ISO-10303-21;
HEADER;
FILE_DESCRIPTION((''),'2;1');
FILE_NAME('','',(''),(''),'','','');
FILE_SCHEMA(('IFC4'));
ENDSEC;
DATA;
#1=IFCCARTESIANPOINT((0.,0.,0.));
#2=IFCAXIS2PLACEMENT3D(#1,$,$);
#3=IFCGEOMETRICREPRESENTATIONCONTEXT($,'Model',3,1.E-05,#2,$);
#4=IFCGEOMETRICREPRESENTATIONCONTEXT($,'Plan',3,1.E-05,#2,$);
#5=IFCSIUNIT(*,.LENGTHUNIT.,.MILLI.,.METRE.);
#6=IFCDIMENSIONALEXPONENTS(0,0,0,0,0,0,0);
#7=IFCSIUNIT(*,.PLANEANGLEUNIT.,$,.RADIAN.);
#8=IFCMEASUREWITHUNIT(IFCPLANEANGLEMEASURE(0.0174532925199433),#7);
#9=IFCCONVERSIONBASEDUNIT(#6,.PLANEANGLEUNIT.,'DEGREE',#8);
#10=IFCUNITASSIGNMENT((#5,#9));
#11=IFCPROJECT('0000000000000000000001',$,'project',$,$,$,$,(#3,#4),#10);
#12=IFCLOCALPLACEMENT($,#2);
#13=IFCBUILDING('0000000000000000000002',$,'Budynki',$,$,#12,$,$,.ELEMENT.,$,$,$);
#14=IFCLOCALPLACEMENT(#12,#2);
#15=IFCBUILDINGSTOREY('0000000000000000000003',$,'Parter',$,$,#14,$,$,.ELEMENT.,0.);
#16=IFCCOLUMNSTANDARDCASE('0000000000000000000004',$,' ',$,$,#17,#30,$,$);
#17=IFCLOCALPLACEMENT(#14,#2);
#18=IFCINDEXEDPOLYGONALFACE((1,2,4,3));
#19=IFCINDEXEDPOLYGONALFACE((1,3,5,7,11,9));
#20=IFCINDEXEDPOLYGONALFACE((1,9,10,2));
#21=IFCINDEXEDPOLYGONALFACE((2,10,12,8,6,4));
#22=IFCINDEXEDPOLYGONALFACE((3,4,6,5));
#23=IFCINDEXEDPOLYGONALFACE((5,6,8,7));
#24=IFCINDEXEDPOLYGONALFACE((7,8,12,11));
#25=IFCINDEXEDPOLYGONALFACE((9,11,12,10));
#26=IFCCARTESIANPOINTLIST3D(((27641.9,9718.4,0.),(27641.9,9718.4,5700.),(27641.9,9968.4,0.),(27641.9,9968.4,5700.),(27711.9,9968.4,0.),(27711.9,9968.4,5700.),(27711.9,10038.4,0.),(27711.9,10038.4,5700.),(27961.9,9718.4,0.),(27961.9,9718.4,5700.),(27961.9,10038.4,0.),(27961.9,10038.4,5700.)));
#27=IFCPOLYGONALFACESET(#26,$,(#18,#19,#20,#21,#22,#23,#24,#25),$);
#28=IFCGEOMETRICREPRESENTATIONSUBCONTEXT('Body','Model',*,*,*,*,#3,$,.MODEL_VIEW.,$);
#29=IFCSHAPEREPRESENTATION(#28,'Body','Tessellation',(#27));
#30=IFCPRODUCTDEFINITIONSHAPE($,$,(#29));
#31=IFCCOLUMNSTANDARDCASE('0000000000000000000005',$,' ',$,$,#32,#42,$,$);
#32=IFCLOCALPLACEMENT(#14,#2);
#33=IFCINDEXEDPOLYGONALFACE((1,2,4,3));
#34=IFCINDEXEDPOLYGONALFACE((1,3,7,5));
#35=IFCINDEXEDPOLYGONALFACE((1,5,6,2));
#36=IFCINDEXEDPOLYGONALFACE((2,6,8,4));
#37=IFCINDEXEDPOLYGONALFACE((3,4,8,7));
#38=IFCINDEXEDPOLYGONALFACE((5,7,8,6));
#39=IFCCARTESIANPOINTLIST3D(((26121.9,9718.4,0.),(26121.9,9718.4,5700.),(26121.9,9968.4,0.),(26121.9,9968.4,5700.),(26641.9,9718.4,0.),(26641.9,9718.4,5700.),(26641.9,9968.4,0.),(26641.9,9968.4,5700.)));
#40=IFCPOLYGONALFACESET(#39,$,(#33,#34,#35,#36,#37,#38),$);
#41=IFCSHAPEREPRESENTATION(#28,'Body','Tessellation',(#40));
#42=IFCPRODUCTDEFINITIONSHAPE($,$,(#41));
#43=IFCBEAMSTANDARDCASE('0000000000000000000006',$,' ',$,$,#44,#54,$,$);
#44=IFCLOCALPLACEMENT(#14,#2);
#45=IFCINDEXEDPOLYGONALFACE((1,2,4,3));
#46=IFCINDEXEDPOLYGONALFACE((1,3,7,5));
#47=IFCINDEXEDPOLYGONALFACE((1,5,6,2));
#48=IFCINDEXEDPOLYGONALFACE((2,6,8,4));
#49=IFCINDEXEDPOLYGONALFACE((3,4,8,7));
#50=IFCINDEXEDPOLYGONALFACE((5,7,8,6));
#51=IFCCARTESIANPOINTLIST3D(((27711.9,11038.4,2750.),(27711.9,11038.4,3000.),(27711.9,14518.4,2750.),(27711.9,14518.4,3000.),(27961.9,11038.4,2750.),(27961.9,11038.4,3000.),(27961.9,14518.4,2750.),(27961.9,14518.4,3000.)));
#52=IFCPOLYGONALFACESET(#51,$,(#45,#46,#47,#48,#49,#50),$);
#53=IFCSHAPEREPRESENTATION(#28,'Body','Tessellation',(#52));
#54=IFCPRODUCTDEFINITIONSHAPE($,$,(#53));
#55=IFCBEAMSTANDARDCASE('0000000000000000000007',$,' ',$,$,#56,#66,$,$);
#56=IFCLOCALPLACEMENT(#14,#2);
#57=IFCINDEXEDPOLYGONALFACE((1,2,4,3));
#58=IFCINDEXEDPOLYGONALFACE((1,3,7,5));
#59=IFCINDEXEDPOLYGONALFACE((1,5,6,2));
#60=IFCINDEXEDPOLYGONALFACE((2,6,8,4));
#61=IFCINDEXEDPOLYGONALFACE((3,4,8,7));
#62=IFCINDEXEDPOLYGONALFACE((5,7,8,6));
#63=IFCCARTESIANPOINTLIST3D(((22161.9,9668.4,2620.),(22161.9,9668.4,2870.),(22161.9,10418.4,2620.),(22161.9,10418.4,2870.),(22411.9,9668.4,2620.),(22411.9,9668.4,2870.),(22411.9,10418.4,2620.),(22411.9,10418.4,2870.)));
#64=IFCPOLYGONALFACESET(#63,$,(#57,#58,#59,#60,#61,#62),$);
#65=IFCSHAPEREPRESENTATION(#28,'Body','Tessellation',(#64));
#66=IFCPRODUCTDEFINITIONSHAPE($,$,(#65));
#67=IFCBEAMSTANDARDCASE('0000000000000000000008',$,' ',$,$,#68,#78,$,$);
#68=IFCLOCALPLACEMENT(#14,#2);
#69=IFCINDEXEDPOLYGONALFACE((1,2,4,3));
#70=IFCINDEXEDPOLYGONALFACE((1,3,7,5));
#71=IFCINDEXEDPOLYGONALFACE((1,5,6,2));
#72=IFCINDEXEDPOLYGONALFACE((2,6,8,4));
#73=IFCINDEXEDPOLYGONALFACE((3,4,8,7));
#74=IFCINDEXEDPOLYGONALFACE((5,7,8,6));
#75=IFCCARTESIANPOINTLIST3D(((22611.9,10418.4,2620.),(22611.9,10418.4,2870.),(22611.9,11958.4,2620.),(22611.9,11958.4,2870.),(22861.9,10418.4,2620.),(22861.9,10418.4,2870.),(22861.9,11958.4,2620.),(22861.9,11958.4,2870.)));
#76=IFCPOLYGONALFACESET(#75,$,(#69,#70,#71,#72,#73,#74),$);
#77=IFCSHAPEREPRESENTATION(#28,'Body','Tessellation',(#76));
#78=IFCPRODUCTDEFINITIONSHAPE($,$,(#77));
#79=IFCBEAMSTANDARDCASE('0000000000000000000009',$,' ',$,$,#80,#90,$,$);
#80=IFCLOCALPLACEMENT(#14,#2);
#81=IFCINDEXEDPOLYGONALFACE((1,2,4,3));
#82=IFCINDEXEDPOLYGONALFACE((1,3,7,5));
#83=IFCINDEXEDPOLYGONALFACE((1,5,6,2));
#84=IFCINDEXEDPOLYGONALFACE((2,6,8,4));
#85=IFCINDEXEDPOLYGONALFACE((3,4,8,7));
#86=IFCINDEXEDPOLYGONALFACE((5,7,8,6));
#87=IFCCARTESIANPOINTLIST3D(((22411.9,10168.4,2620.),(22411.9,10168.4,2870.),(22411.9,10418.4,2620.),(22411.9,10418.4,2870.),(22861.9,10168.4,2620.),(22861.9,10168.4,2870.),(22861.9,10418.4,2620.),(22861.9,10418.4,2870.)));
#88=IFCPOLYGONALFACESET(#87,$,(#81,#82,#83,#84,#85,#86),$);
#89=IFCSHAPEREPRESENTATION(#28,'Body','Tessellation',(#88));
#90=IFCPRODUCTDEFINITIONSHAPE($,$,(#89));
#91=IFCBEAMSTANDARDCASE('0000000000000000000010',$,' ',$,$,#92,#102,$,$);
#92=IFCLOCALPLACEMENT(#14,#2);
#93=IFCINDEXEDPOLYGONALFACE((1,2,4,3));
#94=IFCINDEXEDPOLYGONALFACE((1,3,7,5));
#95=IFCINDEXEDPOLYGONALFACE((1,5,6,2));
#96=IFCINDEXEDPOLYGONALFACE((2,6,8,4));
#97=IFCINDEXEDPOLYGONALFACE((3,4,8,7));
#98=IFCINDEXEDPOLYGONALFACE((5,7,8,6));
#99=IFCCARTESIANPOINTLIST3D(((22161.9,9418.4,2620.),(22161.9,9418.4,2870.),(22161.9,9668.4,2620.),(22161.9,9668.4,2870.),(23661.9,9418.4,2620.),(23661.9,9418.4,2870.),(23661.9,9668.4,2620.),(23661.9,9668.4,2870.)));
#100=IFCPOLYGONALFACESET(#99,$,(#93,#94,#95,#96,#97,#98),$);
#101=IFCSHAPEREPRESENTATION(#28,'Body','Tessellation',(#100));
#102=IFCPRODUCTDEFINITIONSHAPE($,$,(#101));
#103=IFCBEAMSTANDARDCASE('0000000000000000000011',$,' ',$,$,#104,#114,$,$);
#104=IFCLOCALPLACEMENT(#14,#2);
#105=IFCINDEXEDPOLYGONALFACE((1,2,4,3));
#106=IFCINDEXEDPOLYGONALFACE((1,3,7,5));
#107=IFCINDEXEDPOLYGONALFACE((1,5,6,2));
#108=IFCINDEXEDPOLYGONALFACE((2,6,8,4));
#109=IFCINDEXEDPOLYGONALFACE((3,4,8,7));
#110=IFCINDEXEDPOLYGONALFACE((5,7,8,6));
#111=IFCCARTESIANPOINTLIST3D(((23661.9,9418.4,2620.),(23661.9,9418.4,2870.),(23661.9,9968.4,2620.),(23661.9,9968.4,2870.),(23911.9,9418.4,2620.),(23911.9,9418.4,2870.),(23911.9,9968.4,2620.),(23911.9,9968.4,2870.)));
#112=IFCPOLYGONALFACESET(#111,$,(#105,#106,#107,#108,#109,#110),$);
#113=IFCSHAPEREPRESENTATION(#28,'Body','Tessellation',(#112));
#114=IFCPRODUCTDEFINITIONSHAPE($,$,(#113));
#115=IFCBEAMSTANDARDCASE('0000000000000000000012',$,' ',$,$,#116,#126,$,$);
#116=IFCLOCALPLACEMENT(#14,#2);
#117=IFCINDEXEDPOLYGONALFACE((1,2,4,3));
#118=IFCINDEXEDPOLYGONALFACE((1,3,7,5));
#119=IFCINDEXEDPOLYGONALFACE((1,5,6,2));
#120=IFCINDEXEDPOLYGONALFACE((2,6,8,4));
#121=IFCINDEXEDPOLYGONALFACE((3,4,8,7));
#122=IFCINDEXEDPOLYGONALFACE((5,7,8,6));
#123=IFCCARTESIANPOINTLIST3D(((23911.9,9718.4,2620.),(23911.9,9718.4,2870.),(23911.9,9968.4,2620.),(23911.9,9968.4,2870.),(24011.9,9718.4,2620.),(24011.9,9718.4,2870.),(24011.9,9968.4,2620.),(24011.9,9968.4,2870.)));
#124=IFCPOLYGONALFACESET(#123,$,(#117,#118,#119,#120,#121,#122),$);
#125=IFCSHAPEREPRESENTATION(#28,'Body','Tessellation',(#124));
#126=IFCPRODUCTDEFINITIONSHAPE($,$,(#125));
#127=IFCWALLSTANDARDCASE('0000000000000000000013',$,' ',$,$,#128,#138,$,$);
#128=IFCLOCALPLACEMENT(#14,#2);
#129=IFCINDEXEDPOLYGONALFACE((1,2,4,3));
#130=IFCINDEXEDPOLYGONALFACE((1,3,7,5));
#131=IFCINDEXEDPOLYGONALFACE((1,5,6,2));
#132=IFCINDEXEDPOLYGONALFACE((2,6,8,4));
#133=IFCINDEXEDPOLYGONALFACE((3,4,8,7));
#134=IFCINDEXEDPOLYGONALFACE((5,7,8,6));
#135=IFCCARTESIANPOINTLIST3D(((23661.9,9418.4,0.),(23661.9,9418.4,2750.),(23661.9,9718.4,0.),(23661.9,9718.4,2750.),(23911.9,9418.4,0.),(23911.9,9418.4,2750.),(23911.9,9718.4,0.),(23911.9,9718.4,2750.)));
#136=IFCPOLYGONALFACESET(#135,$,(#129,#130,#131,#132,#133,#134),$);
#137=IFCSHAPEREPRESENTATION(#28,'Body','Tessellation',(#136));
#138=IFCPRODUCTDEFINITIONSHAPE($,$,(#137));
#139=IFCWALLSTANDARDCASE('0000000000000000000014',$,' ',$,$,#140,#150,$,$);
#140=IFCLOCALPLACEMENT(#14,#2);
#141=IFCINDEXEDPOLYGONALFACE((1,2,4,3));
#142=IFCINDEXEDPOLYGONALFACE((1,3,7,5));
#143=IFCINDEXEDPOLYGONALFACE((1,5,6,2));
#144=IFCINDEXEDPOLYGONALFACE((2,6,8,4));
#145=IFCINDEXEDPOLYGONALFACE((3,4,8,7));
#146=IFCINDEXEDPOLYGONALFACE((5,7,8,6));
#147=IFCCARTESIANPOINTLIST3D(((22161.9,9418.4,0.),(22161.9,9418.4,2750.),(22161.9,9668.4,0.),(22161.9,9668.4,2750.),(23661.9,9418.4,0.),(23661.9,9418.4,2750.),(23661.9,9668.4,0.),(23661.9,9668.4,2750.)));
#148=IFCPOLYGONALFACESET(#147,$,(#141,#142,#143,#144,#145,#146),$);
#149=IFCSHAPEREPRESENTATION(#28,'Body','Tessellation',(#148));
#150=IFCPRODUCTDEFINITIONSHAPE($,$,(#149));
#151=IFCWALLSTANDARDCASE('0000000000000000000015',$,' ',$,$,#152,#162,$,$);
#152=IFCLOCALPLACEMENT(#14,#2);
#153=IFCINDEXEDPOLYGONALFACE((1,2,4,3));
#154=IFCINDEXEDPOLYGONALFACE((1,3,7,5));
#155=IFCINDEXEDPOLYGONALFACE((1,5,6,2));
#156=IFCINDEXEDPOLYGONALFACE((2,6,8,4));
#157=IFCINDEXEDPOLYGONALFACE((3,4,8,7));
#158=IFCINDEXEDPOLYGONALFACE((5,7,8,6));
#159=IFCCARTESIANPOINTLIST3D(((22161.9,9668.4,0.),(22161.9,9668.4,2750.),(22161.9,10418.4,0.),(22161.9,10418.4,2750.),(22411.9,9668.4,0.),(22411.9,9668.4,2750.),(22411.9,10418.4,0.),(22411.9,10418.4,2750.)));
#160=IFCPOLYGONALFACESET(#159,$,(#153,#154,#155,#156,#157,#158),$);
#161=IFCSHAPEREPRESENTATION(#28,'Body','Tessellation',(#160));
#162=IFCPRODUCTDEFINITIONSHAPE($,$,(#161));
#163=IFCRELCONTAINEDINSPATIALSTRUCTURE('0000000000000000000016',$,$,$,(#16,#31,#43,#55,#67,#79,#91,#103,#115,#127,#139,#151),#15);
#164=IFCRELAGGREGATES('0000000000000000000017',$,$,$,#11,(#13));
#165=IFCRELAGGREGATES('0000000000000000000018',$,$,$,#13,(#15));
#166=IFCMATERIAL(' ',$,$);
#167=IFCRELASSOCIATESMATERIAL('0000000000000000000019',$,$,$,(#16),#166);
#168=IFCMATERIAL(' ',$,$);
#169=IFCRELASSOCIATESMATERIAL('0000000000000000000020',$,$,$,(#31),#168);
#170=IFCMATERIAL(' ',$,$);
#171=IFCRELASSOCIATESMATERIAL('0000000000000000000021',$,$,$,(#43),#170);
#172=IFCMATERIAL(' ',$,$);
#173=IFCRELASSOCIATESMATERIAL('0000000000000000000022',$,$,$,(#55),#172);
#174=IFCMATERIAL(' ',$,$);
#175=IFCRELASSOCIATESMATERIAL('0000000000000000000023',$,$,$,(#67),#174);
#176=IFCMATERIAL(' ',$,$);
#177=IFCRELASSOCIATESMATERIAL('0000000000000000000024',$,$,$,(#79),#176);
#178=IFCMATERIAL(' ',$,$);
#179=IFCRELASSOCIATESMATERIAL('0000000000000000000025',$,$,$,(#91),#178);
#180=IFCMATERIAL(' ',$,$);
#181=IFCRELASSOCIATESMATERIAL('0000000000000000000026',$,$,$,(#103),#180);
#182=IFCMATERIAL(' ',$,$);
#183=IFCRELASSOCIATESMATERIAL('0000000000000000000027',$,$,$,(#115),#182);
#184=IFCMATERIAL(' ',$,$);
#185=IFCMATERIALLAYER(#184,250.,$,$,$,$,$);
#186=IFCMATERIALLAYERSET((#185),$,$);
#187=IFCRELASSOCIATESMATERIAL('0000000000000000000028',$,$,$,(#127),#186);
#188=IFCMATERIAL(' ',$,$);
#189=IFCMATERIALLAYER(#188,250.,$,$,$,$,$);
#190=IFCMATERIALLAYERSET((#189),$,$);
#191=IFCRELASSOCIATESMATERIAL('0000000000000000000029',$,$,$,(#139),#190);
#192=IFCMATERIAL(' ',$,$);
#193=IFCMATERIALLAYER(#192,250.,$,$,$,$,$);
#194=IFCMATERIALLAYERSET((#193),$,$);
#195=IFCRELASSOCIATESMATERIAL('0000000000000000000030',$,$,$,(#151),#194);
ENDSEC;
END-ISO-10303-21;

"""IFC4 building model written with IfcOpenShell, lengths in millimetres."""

from ifc_helpers import new_model, entity, si_unit, converted_unit, frame, frame_2d, origin, origin_with_axes, place, context, subcontext, project, spatial, polyline, rectangle, outline, extrude, material, layer, layer_set, layer_usage, material_profile, profile_set, profile_usage, element, save


model = new_model("IFC4")

# Units and contexts
model_context = context("Model", 3, precision=1e-05, world=origin())
plan_context = context("Plan", 3, precision=1e-05, world=origin())
body_context = subcontext(model_context, "Body", "Model", "MODEL_VIEW")
ifc_project = project(units=[si_unit("LENGTHUNIT", "METRE", prefix="MILLI"), converted_unit("PLANEANGLEUNIT", "DEGREE", entity("IfcPlaneAngleMeasure", 0.0174532925199433), si_unit("PLANEANGLEUNIT", "RADIAN"), dimensions=[0, 0, 0, 0, 0, 0, 0])], contexts=[model_context, plan_context])

# Building, storey
building_placement = place(None, origin())
building = spatial("IfcBuilding", under=ifc_project, at=building_placement, Name="Budynki", CompositionType="ELEMENT")
storey_placement = place(building_placement, origin())
storey = spatial("IfcBuildingStorey", under=building, at=storey_placement, Name="Parter", CompositionType="ELEMENT", Elevation=0.0)

# Columns
ifc_material_1 = material(Name=" ")
ifc_material_profile_1 = material_profile(ifc_material_1, outline(polyline([(0.0, 0.0), (320.0, 0.0), (320.0, 320.0), (70.0, 320.0), (70.0, 250.0), (0.0, 250.0), (0.0, 0.0)])))
ifc_profile_set_1 = profile_set([ifc_material_profile_1])
ifc_profile_usage_1 = profile_usage(ifc_profile_set_1)
column_1_placement = place(storey_placement, frame((27641.9, 9718.4, 0.0)))
element("IfcColumnStandardCase", 1, at=column_1_placement, inside=storey, material=ifc_profile_usage_1, Name=" ", context=body_context, shape_type="SweptSolid", body=[
    extrude(outline(polyline([(0.0, 0.0), (320.0, 0.0), (320.0, 320.0), (70.0, 320.0), (70.0, 250.0), (0.0, 250.0), (0.0, 0.0)])), origin_with_axes(), (0.0, 0.0, 1.0), 5700.0),
])
ifc_material_2 = material(Name=" ")
ifc_material_profile_2 = material_profile(ifc_material_2, outline(polyline([(0.0, 0.0), (520.0, 0.0), (520.0, 250.0), (0.0, 250.0), (0.0, 0.0)])))
ifc_profile_set_2 = profile_set([ifc_material_profile_2])
ifc_profile_usage_2 = profile_usage(ifc_profile_set_2)
column_2_placement = place(storey_placement, frame((26121.9, 9718.4, 0.0)))
element("IfcColumnStandardCase", 2, at=column_2_placement, inside=storey, material=ifc_profile_usage_2, Name=" ", context=body_context, shape_type="SweptSolid", body=[
    extrude(outline(polyline([(0.0, 0.0), (520.0, 0.0), (520.0, 250.0), (0.0, 250.0), (0.0, 0.0)])), origin_with_axes(), (0.0, 0.0, 1.0), 5700.0),
])

# Beams
ifc_material_3 = material(Name=" ")
ifc_material_profile_3 = material_profile(ifc_material_3, rectangle(XDim=250.0, YDim=250.0, at=frame_2d((125.0, -125.0), x_axis=(0.0, 1.0))))
ifc_profile_set_3 = profile_set([ifc_material_profile_3])
ifc_profile_usage_3 = profile_usage(ifc_profile_set_3)
beam_1_placement = place(storey_placement, frame((27961.9, 11038.4, 2750.0), z_axis=(0.0, 0.0, 1.0), x_axis=(0.0, 1.0, 0.0)))
element("IfcBeamStandardCase", 3, at=beam_1_placement, inside=storey, material=ifc_profile_usage_3, Name=" ", context=body_context, shape_type="SweptSolid", body=[
    extrude(rectangle(XDim=250.0, YDim=250.0, at=frame_2d((125.0, -125.0), x_axis=(0.0, 1.0))), frame((0.0, 0.0, 0.0), z_axis=(1.0, 0.0, 0.0), x_axis=(0.0, 0.0, 1.0)), (0.0, 0.0, 1.0), 3480.0),
])
ifc_material_4 = material(Name=" ")
ifc_material_profile_4 = material_profile(ifc_material_4, rectangle(XDim=250.0, YDim=250.0, at=frame_2d((125.0, -125.0), x_axis=(0.0, 1.0))))
ifc_profile_set_4 = profile_set([ifc_material_profile_4])
ifc_profile_usage_4 = profile_usage(ifc_profile_set_4)
beam_2_placement = place(storey_placement, frame((22161.9, 10418.4, 2620.0), z_axis=(0.0, 0.0, 1.0), x_axis=(0.0, -1.0, 0.0)))
element("IfcBeamStandardCase", 4, at=beam_2_placement, inside=storey, material=ifc_profile_usage_4, Name=" ", context=body_context, shape_type="SweptSolid", body=[
    extrude(rectangle(XDim=250.0, YDim=250.0, at=frame_2d((125.0, -125.0), x_axis=(0.0, 1.0))), frame((0.0, 0.0, 0.0), z_axis=(1.0, 0.0, 0.0), x_axis=(0.0, 0.0, 1.0)), (0.0, 0.0, 1.0), 750.0),
])
ifc_material_5 = material(Name=" ")
ifc_material_profile_5 = material_profile(ifc_material_5, rectangle(XDim=250.0, YDim=250.0, at=frame_2d((125.0, -125.0), x_axis=(0.0, 1.0))))
ifc_profile_set_5 = profile_set([ifc_material_profile_5])
ifc_profile_usage_5 = profile_usage(ifc_profile_set_5)
beam_3_placement = place(storey_placement, frame((22611.9, 11958.4, 2620.0), z_axis=(0.0, 0.0, 1.0), x_axis=(0.0, -1.0, 0.0)))
element("IfcBeamStandardCase", 5, at=beam_3_placement, inside=storey, material=ifc_profile_usage_5, Name=" ", context=body_context, shape_type="SweptSolid", body=[
    extrude(rectangle(XDim=250.0, YDim=250.0, at=frame_2d((125.0, -125.0), x_axis=(0.0, 1.0))), frame((0.0, 0.0, 0.0), z_axis=(1.0, 0.0, 0.0), x_axis=(0.0, 0.0, 1.0)), (0.0, 0.0, 1.0), 1540.0),
])
ifc_material_6 = material(Name=" ")
ifc_material_profile_6 = material_profile(ifc_material_6, rectangle(XDim=250.0, YDim=250.0, at=frame_2d((125.0, -125.0), x_axis=(0.0, 1.0))))
ifc_profile_set_6 = profile_set([ifc_material_profile_6])
ifc_profile_usage_6 = profile_usage(ifc_profile_set_6)
beam_4_placement = place(storey_placement, frame((22861.9, 10418.4, 2620.0), z_axis=(0.0, 0.0, 1.0), x_axis=(-1.0, 0.0, 0.0)))
element("IfcBeamStandardCase", 6, at=beam_4_placement, inside=storey, material=ifc_profile_usage_6, Name=" ", context=body_context, shape_type="SweptSolid", body=[
    extrude(rectangle(XDim=250.0, YDim=250.0, at=frame_2d((125.0, -125.0), x_axis=(0.0, 1.0))), frame((0.0, 0.0, 0.0), z_axis=(1.0, 0.0, 0.0), x_axis=(0.0, 0.0, 1.0)), (0.0, 0.0, 1.0), 450.0),
])
ifc_material_7 = material(Name=" ")
ifc_material_profile_7 = material_profile(ifc_material_7, rectangle(XDim=250.0, YDim=250.0, at=frame_2d((125.0, -125.0), x_axis=(0.0, 1.0))))
ifc_profile_set_7 = profile_set([ifc_material_profile_7])
ifc_profile_usage_7 = profile_usage(ifc_profile_set_7)
beam_5_placement = place(storey_placement, frame((22161.9, 9418.4, 2620.0)))
element("IfcBeamStandardCase", 7, at=beam_5_placement, inside=storey, material=ifc_profile_usage_7, Name=" ", context=body_context, shape_type="SweptSolid", body=[
    extrude(rectangle(XDim=250.0, YDim=250.0, at=frame_2d((125.0, -125.0), x_axis=(0.0, 1.0))), frame((0.0, 0.0, 0.0), z_axis=(1.0, 0.0, 0.0), x_axis=(0.0, 0.0, 1.0)), (0.0, 0.0, 1.0), 1500.0),
])
ifc_material_8 = material(Name=" ")
ifc_material_profile_8 = material_profile(ifc_material_8, rectangle(XDim=250.0, YDim=250.0, at=frame_2d((125.0, -125.0), x_axis=(0.0, 1.0))))
ifc_profile_set_8 = profile_set([ifc_material_profile_8])
ifc_profile_usage_8 = profile_usage(ifc_profile_set_8)
beam_6_placement = place(storey_placement, frame((23911.9, 9418.4, 2620.0), z_axis=(0.0, 0.0, 1.0), x_axis=(0.0, 1.0, 0.0)))
element("IfcBeamStandardCase", 8, at=beam_6_placement, inside=storey, material=ifc_profile_usage_8, Name=" ", context=body_context, shape_type="SweptSolid", body=[
    extrude(rectangle(XDim=250.0, YDim=250.0, at=frame_2d((125.0, -125.0), x_axis=(0.0, 1.0))), frame((0.0, 0.0, 0.0), z_axis=(1.0, 0.0, 0.0), x_axis=(0.0, 0.0, 1.0)), (0.0, 0.0, 1.0), 550.0),
])
ifc_material_9 = material(Name=" ")
ifc_material_profile_9 = material_profile(ifc_material_9, rectangle(XDim=250.0, YDim=250.0, at=frame_2d((125.0, -125.0), x_axis=(0.0, 1.0))))
ifc_profile_set_9 = profile_set([ifc_material_profile_9])
ifc_profile_usage_9 = profile_usage(ifc_profile_set_9)
beam_7_placement = place(storey_placement, frame((23911.9, 9718.4, 2620.0)))
element("IfcBeamStandardCase", 9, at=beam_7_placement, inside=storey, material=ifc_profile_usage_9, Name=" ", context=body_context, shape_type="SweptSolid", body=[
    extrude(rectangle(XDim=250.0, YDim=250.0, at=frame_2d((125.0, -125.0), x_axis=(0.0, 1.0))), frame((0.0, 0.0, 0.0), z_axis=(1.0, 0.0, 0.0), x_axis=(0.0, 0.0, 1.0)), (0.0, 0.0, 1.0), 100.0),
])

# Walls
ifc_material_10 = material(Name=" ")
ifc_layer_1 = layer(ifc_material_10, 250.0)
ifc_layer_set_1 = layer_set([ifc_layer_1])
ifc_layer_usage_1 = layer_usage(ifc_layer_set_1, "AXIS2", "POSITIVE", 0.0)
wall_1_placement = place(storey_placement, frame((23661.9, 9718.4, 0.0), z_axis=(0.0, 0.0, 1.0), x_axis=(0.0, -1.0, 0.0)))
element("IfcWallStandardCase", 10, at=wall_1_placement, inside=storey, material=ifc_layer_usage_1, Name=" ", context=body_context, shape_type="SweptSolid", body=[
    extrude(rectangle(XDim=300.0, YDim=250.0, at=frame_2d((150.0, 125.0), x_axis=(1.0, 0.0))), origin_with_axes(), (0.0, 0.0, 1.0), 2750.0),
])
ifc_material_11 = material(Name=" ")
ifc_layer_2 = layer(ifc_material_11, 250.0)
ifc_layer_set_2 = layer_set([ifc_layer_2])
ifc_layer_usage_2 = layer_usage(ifc_layer_set_2, "AXIS2", "POSITIVE", 0.0)
wall_2_placement = place(storey_placement, frame((23661.9, 9668.4, 0.0), z_axis=(0.0, 0.0, 1.0), x_axis=(-1.0, 0.0, 0.0)))
element("IfcWallStandardCase", 11, at=wall_2_placement, inside=storey, material=ifc_layer_usage_2, Name=" ", context=body_context, shape_type="SweptSolid", body=[
    extrude(rectangle(XDim=1500.0, YDim=250.0, at=frame_2d((750.0, 125.0), x_axis=(1.0, 0.0))), origin_with_axes(), (0.0, 0.0, 1.0), 2750.0),
])
ifc_material_12 = material(Name=" ")
ifc_layer_3 = layer(ifc_material_12, 250.0)
ifc_layer_set_3 = layer_set([ifc_layer_3])
ifc_layer_usage_3 = layer_usage(ifc_layer_set_3, "AXIS2", "POSITIVE", 0.0)
wall_3_placement = place(storey_placement, frame((22411.9, 9668.4, 0.0), z_axis=(0.0, 0.0, 1.0), x_axis=(0.0, 1.0, 0.0)))
element("IfcWallStandardCase", 12, at=wall_3_placement, inside=storey, material=ifc_layer_usage_3, Name=" ", context=body_context, shape_type="SweptSolid", body=[
    extrude(rectangle(XDim=750.0, YDim=250.0, at=frame_2d((375.0, 125.0), x_axis=(1.0, 0.0))), origin_with_axes(), (0.0, 0.0, 1.0), 2750.0),
])

save(model, "model.ifc")
